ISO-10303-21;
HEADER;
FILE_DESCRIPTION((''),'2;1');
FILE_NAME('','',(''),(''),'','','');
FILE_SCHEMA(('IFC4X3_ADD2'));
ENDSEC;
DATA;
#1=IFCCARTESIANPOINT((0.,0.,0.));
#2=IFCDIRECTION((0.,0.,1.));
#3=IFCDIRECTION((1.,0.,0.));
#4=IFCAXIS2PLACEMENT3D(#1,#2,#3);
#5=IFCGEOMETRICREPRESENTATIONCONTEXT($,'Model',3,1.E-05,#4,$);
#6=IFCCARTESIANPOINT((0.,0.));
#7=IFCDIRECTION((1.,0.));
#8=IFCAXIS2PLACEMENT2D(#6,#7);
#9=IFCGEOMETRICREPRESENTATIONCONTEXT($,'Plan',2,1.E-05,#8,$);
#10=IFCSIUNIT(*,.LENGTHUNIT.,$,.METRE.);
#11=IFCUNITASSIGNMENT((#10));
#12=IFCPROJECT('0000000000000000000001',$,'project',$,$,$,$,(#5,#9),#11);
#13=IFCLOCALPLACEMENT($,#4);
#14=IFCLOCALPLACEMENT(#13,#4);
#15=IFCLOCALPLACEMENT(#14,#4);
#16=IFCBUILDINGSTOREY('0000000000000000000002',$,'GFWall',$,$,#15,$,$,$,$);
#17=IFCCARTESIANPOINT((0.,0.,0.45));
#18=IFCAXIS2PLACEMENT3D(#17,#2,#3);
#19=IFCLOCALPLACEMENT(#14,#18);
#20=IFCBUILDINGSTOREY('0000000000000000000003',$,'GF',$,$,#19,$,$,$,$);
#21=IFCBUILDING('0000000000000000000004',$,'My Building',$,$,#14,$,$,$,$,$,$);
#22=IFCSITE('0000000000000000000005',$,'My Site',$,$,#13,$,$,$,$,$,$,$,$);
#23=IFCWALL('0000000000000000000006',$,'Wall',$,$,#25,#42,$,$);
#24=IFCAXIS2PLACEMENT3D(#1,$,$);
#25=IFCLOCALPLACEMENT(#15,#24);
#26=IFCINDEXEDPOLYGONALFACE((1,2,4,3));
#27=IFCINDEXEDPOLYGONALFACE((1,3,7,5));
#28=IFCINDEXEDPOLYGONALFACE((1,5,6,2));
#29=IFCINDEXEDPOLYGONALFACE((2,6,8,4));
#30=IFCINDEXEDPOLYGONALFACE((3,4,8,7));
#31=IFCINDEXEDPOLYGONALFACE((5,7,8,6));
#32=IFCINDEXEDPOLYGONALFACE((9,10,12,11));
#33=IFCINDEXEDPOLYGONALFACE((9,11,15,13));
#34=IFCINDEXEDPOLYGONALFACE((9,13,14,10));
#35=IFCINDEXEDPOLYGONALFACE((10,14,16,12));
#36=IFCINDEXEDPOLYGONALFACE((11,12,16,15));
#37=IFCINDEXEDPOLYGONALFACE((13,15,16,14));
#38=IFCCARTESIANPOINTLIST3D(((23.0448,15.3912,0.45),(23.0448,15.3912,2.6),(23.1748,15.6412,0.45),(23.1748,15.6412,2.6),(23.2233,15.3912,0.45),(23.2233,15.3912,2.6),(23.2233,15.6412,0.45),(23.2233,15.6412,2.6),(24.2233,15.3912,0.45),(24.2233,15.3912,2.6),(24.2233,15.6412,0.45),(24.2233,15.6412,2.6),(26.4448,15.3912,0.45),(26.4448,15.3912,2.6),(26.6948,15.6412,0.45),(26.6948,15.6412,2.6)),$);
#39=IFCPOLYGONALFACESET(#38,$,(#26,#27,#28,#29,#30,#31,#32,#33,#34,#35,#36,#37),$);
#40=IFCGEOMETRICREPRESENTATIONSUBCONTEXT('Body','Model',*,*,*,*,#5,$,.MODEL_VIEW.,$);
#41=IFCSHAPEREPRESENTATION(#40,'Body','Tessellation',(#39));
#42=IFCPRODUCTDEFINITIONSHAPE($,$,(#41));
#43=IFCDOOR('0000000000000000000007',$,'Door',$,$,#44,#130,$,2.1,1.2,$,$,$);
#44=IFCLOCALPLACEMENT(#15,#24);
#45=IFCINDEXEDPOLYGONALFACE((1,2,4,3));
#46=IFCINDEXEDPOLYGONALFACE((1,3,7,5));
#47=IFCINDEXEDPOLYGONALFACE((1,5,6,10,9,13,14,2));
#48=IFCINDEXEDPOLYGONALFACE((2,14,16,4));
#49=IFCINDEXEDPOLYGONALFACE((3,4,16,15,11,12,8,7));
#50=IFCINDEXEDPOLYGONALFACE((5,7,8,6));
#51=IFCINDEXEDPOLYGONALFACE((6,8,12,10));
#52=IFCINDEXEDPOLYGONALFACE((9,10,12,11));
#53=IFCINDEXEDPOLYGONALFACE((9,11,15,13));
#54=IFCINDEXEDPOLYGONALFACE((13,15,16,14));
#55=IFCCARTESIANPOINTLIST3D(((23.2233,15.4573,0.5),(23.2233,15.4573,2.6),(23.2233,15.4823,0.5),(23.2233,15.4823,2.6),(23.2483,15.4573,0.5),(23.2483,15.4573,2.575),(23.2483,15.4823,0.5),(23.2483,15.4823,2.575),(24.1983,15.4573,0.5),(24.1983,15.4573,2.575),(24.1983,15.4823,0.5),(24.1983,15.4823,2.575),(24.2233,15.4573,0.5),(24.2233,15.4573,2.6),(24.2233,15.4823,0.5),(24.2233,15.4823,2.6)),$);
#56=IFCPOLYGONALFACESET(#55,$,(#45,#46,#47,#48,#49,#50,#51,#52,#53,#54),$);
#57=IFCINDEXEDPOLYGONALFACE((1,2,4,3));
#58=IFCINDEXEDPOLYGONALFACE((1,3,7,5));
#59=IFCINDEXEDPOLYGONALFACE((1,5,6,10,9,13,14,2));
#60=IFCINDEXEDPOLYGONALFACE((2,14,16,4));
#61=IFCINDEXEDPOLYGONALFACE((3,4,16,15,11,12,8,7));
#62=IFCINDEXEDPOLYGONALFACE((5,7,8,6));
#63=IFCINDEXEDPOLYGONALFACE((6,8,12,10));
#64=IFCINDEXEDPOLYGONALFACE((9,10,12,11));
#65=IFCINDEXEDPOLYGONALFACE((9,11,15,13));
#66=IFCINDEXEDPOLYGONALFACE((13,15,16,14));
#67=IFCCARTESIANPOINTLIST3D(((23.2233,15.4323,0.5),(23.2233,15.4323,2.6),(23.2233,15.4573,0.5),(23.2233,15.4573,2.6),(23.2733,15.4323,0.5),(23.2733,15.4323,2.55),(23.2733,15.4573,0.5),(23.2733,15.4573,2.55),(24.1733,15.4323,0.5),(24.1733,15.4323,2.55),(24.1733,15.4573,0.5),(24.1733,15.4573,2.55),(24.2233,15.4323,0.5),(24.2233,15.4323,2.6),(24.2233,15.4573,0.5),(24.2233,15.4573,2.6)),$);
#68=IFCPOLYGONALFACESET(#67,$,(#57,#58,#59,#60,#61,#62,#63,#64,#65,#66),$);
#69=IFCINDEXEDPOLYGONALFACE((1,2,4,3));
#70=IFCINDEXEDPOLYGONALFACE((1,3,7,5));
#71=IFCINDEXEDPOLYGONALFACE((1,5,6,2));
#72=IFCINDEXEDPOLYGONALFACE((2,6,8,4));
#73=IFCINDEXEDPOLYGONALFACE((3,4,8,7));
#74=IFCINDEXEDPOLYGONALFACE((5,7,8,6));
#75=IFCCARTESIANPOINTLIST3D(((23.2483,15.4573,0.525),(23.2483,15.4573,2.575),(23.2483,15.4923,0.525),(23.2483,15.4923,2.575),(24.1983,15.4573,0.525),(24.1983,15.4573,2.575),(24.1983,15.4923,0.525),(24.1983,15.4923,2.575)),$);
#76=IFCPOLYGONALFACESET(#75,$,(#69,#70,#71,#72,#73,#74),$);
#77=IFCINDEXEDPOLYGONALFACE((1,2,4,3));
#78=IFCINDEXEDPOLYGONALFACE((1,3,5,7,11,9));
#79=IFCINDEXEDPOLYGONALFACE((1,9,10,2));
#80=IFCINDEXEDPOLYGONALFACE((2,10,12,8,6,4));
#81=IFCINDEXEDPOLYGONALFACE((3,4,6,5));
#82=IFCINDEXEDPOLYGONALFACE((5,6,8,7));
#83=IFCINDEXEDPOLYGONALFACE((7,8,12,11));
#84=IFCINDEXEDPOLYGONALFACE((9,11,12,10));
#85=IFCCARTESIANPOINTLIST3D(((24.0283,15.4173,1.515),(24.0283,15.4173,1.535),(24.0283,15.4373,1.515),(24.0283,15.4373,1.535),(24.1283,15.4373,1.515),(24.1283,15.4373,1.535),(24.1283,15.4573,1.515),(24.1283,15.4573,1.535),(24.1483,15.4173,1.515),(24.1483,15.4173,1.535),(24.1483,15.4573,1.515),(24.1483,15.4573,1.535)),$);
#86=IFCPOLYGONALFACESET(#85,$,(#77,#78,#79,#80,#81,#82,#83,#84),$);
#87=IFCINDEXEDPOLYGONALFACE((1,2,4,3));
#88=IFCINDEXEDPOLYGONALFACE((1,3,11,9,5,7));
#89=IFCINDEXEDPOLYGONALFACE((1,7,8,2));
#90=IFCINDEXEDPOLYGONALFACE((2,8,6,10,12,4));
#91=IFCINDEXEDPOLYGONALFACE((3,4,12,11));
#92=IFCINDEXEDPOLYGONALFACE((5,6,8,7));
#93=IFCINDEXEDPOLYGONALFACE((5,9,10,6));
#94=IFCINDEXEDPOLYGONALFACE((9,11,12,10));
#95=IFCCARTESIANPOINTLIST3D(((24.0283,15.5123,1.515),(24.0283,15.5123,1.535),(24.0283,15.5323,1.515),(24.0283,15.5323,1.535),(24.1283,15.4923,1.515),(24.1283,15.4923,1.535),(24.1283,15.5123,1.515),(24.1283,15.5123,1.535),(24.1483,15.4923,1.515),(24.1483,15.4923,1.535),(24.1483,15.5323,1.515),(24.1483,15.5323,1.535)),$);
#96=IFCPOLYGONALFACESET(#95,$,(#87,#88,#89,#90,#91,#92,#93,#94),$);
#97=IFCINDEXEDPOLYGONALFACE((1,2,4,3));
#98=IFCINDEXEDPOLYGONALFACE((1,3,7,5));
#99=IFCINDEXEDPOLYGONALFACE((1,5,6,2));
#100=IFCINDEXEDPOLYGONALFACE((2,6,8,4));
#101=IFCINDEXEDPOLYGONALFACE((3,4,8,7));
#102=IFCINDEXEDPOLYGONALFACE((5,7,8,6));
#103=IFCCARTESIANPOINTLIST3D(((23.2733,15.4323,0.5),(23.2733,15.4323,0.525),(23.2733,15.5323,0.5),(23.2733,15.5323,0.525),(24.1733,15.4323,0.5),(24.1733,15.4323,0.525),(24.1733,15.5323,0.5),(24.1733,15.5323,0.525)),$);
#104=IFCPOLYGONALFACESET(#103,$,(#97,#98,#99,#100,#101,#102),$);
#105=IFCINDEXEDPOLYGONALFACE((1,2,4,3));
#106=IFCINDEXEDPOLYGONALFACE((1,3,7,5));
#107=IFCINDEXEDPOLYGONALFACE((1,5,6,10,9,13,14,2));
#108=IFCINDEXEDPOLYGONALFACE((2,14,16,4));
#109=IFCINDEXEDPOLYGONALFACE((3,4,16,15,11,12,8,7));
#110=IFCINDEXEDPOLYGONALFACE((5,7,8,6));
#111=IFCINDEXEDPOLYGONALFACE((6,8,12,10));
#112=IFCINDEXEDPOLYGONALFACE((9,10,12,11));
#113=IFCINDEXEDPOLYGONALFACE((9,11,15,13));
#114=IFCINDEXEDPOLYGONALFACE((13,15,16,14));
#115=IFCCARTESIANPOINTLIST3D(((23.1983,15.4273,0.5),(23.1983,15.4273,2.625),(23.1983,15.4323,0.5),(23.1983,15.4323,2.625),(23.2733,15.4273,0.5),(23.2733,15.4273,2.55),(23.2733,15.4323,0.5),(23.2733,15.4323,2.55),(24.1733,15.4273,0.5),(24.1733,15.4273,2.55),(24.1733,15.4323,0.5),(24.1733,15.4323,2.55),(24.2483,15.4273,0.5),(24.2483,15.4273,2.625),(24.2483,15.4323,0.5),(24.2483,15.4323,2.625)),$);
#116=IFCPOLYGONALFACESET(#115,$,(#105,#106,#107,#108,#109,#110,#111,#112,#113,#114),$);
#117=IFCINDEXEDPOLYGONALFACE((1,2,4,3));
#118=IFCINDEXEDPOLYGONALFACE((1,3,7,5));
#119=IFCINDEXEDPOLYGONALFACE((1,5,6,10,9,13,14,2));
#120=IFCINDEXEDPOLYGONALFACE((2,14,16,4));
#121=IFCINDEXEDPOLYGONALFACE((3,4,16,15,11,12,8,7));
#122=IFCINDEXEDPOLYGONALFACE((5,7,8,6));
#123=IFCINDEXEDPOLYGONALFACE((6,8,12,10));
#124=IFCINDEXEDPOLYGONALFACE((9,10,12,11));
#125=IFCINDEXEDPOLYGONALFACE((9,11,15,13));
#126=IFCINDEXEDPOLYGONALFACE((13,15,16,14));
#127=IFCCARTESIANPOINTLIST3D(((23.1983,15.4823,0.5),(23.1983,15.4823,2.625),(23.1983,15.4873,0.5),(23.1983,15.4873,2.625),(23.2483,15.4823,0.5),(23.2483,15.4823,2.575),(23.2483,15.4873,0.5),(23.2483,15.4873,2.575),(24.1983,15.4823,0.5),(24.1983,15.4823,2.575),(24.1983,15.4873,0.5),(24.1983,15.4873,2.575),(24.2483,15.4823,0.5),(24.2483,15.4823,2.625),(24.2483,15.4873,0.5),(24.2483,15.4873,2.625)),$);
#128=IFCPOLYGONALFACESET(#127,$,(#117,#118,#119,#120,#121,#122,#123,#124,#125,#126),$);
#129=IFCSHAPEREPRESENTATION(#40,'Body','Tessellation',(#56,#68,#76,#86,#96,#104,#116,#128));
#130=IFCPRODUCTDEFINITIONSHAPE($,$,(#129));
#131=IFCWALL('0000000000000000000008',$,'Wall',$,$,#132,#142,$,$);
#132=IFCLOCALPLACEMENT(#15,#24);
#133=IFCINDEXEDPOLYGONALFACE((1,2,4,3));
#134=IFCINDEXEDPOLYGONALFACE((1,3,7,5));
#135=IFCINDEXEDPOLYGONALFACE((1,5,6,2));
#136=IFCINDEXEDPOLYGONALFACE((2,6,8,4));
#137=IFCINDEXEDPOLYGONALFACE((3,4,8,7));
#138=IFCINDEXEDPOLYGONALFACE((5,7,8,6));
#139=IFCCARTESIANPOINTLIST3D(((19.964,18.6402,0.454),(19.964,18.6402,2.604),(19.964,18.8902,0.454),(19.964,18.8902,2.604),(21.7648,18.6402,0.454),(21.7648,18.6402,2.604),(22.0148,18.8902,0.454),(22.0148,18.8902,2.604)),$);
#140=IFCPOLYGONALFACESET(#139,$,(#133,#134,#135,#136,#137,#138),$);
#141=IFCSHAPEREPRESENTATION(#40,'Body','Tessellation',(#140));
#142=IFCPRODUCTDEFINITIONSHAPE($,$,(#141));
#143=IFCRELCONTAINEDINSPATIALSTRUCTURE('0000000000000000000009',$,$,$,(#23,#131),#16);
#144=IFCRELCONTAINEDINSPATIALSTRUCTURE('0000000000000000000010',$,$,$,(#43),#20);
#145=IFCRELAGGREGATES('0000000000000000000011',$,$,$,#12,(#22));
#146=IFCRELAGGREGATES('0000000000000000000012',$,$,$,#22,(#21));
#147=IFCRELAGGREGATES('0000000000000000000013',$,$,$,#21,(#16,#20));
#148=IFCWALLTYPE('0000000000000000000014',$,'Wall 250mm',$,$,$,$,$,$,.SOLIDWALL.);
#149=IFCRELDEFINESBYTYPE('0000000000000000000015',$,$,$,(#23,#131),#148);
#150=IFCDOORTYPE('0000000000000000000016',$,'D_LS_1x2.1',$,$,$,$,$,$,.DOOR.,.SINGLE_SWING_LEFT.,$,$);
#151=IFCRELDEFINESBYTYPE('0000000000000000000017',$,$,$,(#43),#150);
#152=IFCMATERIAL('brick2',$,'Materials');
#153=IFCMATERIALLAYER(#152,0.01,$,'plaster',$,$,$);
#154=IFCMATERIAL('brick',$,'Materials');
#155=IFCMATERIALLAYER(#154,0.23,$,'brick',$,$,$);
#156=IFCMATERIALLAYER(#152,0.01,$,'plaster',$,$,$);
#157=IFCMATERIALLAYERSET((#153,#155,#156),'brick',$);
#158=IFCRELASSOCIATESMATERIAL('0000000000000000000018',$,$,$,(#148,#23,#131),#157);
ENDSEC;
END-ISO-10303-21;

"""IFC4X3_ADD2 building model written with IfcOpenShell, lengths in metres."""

from ifc_helpers import new_model, entity, si_unit, frame, origin_with_axes, origin_2d_with_axis, place, context, subcontext, project, spatial, line, indexed_curve, outline, extrude, shape, source, transform, mapped, material, layer, layer_set, layer_usage, type_object, type_shapes, element, fill, save


model = new_model("IFC4X3_ADD2")

# Units and contexts
model_context = context("Model", 3, precision=1e-05, world=origin_with_axes())
plan_context = context("Plan", 2, precision=1e-05, world=origin_2d_with_axis())
body_context_1 = subcontext(model_context, "Body", "Model", "MODEL_VIEW")
body_context_2 = subcontext(plan_context, "Body", "Plan", "PLAN_VIEW")
ifc_project = project(units=[si_unit("LENGTHUNIT", "METRE")], contexts=[model_context, plan_context])

# Site, building, storey
site_placement = place(None, origin_with_axes())
site = spatial("IfcSite", under=ifc_project, at=site_placement, Name="My Site")
building_placement = place(site_placement, origin_with_axes())
building = spatial("IfcBuilding", under=site, at=building_placement, Name="My Building")
storey_1_placement = place(building_placement, origin_with_axes())
storey_1 = spatial("IfcBuildingStorey", under=building, at=storey_1_placement, Name="GFWall")

# Shared definitions
ifc_material_1 = material(Name="brick2", Category="Materials")
ifc_layer_1 = layer(ifc_material_1, 0.01, Name="plaster")
ifc_material_2 = material(Name="brick", Category="Materials")
ifc_layer_2 = layer(ifc_material_2, 0.23, Name="brick")
ifc_layer_3 = layer(ifc_material_1, 0.01, Name="plaster")
ifc_layer_set_1 = layer_set([ifc_layer_1, ifc_layer_2, ifc_layer_3], Name="brick")
wall_type_1 = type_object("IfcWallType", Name="Wall 250mm", PredefinedType="SOLIDWALL", material=ifc_layer_set_1)

# Shared definitions
storey_2_placement = place(building_placement, frame((0.0, 0.0, 0.45), z_axis=(0.0, 0.0, 1.0), x_axis=(1.0, 0.0, 0.0)))
storey_2 = spatial("IfcBuildingStorey", under=building, at=storey_2_placement, Name="GF")

# Shared definitions
shared_shape_1 = source(origin_with_axes(), body_context_1, "Body", "SweptSolid", [
    extrude(outline(indexed_curve([(0.0, 2.1), (1.0, 2.1), (1.0, -0.05), (0.0, -0.05), (0.0, 2.1)])), frame((0.0, -0.6, 0.0), z_axis=(0.0, -1.0, 0.0), x_axis=(1.0, 0.0, 0.0)), (0.0, 0.0, -1.0), 1.2),
])
door_type_1 = type_object("IfcDoorType", Name="D_LS_1x2.1", OperationType="SINGLE_SWING_LEFT", PredefinedType="DOOR")
shared_shape_2 = source(origin_with_axes(), body_context_1, "Body", "SweptSolid", [
    extrude(outline(indexed_curve([(0.0, 0.0), (0.0, 2.1), (1.0, 2.1), (1.0, 0.0), (0.975, 0.0), (0.975, 2.075), (0.025, 2.075), (0.025, 0.0)], segments=[line(1, 2, 3, 4, 5, 6, 7, 8, 1)])), frame((0.0, 0.025, 0.0), z_axis=(0.0, -1.0, 0.0), x_axis=(1.0, 0.0, 0.0)), (0.0, 0.0, -1.0), 0.025),
    extrude(outline(indexed_curve([(0.0, 0.0), (0.0, 2.1), (1.0, 2.1), (1.0, 0.0), (0.95, 0.0), (0.95, 2.05), (0.05, 2.05), (0.05, 0.0)], segments=[line(1, 2, 3, 4, 5, 6, 7, 8, 1)])), frame((0.0, 0.0, 0.0), z_axis=(0.0, -1.0, 0.0), x_axis=(1.0, 0.0, 0.0)), (0.0, 0.0, -1.0), 0.025),
    extrude(outline(indexed_curve([(0.0, 0.0), (0.95, 0.0), (0.95, 0.035), (0.0, 0.035)], segments=[line(1, 2, 3, 4, 1)])), frame((0.025, 0.025, 0.025), z_axis=(0.0, 0.0, 1.0), x_axis=(1.0, 0.0, 0.0)), (0.0, 0.0, 1.0), 2.05),
    extrude(outline(indexed_curve([(0.0, 0.0), (0.0, -0.04), (-0.12, -0.04), (-0.12, -0.02), (-0.02, -0.02), (-0.02, 0.0)], segments=[line(1, 2, 3, 4, 5, 6, 1)])), frame((0.925, 0.025, 1.015), z_axis=(0.0, 0.0, 1.0), x_axis=(1.0, 0.0, 0.0)), (0.0, 0.0, 1.0), 0.02),
    extrude(outline(indexed_curve([(0.0, 0.0), (0.0, 0.04), (-0.12, 0.04), (-0.12, 0.02), (-0.02, 0.02), (-0.02, 0.0)], segments=[line(1, 2, 3, 4, 5, 6, 1)])), frame((0.925, 0.06, 1.015), z_axis=(0.0, 0.0, 1.0), x_axis=(1.0, 0.0, 0.0)), (0.0, 0.0, 1.0), 0.02),
    extrude(outline(indexed_curve([(0.0, 0.0), (0.9, 0.0), (0.9, 0.1), (0.0, 0.1)], segments=[line(1, 2, 3, 4, 1)])), frame((0.05, 0.0, 0.0), z_axis=(0.0, 0.0, 1.0), x_axis=(1.0, 0.0, 0.0)), (0.0, 0.0, 1.0), 0.025),
    extrude(outline(indexed_curve([(0.0, 0.0), (0.0, 2.125), (1.05, 2.125), (1.05, 0.0), (0.975, 0.0), (0.975, 2.05), (0.075, 2.05), (0.075, 0.0)], segments=[line(1, 2, 3, 4, 5, 6, 7, 8, 1)])), frame((-0.025, -0.005, 0.0), z_axis=(0.0, -1.0, 0.0), x_axis=(1.0, 0.0, 0.0)), (0.0, 0.0, -1.0), 0.005),
    extrude(outline(indexed_curve([(0.0, 0.0), (0.0, 2.125), (1.05, 2.125), (1.05, 0.0), (1.0, 0.0), (1.0, 2.075), (0.05, 2.075), (0.05, 0.0)], segments=[line(1, 2, 3, 4, 5, 6, 7, 8, 1)])), frame((-0.025, 0.05, 0.0), z_axis=(0.0, -1.0, 0.0), x_axis=(1.0, 0.0, 0.0)), (0.0, 0.0, -1.0), 0.005),
])
shared_shape_3 = source(origin_with_axes(), body_context_2, "Body", "Curve2D", [
    entity("IfcIndexedPolyCurve", entity("IfcCartesianPointList2D", [[0.0, 0.0], [0.0, 0.05], [0.025, 0.05], [0.025, 0.025], [0.05, 0.025], [0.05, 0.0]]), [entity("IfcLineIndex", [1, 2, 3, 4, 5, 6, 1])]),
    entity("IfcIndexedPolyCurve", entity("IfcCartesianPointList2D", [[1.0, 0.0], [1.0, 0.05], [0.975, 0.05], [0.975, 0.025], [0.95, 0.025], [0.95, 0.0]]), [entity("IfcLineIndex", [1, 2, 3, 4, 5, 6, 1])]),
    entity("IfcTrimmedCurve", entity("IfcEllipse", entity("IfcAxis2Placement2D", entity("IfcCartesianPoint", [0.06, 0.05]), entity("IfcDirection", [1.0, 0.0])), 0.915, 0.95), [entity("IfcCartesianPoint", [0.975, 0.05])], [entity("IfcCartesianPoint", [0.06, 1.0])], True, "CARTESIAN"),
    entity("IfcIndexedPolyCurve", entity("IfcCartesianPointList2D", [[0.025, 0.05], [0.06, 0.05], [0.06, 1.0], [0.025, 1.0]]), [entity("IfcLineIndex", [1, 2, 3, 4, 1])]),
])
type_shapes(door_type_1, [shared_shape_2, shared_shape_3])

# Wall, opening, door
ifc_layer_usage_1 = layer_usage(ifc_layer_set_1, "AXIS2", "POSITIVE", 0.0)
wall_1_placement = place(storey_1_placement, frame((26.6948, 15.6412, 0.45), z_axis=(0.0, 0.0, 1.0), x_axis=(-1.0, 0.0, 0.0)))
wall_1 = element("IfcWall", 1, at=wall_1_placement, inside=storey_1, type_object=wall_type_1, material=ifc_layer_usage_1, Name="Wall", context=body_context_1, shape_type="SweptSolid", body=[
    extrude(outline(indexed_curve([(0.0, 0.0), (0.25, 0.25), (3.65, 0.25), (3.52, 0.0)], segments=[line(1, 2, 3, 4, 1)])), origin_with_axes(), (0.0, 0.0, 1.0), 2.15),
])
opening_1_placement = place(wall_1_placement, frame((3.4715, 0.209, 0.05), z_axis=(0.0, 0.0, 1.0), x_axis=(-1.0, 0.0, 0.0)))
opening_1 = element("IfcOpeningElement", 2, at=opening_1_placement, cuts=wall_1, PredefinedType="OPENING", context=body_context_1, shape_type="MappedRepresentation", body=[
    mapped(shared_shape_1, transform((0.0, 0.0, 0.0), x_axis=(1.0, 0.0, 0.0), y_axis=(0.0, 1.0, 0.0), z_axis=(0.0, 0.0, 1.0), scale=1.0)),
])
door_1_placement = place(opening_1_placement, frame((0.0, 0.0, 0.0), z_axis=(0.0, 0.0, 1.0), x_axis=(1.0, 0.0, 0.0)))
door_1 = element("IfcDoor", 3, at=door_1_placement, inside=storey_2, type_object=door_type_1, Name="Door", OverallHeight=2.1, OverallWidth=1.2, shapes=[
    shape(body_context_1, "Body", "MappedRepresentation", [mapped(shared_shape_2, transform((0.0, 0.0, 0.0), x_axis=(1.0, 0.0, 0.0), y_axis=(0.0, 1.0, 0.0), z_axis=(0.0, 0.0, 1.0), scale=1.0))]),
    shape(body_context_2, "Body", "MappedRepresentation", [mapped(shared_shape_3, transform((0.0, 0.0, 0.0), x_axis=(1.0, 0.0, 0.0), y_axis=(0.0, 1.0, 0.0), z_axis=(0.0, 0.0, 1.0), scale=1.0))]),
])
fill(opening_1, door_1)

# Wall
ifc_layer_usage_2 = layer_usage(ifc_layer_set_1, "AXIS2", "POSITIVE", 0.0)
wall_2_placement = place(storey_1_placement, frame((19.714, 18.6402, 0.454), z_axis=(0.0, 0.0, 1.0), x_axis=(1.0, -0.000001, 0.0)))
element("IfcWall", 4, at=wall_2_placement, inside=storey_1, type_object=wall_type_1, material=ifc_layer_usage_2, Name="Wall", context=body_context_1, shape_type="SweptSolid", body=[
    extrude(outline(indexed_curve([(0.25, 0.0), (0.25, 0.25), (2.3008, 0.25), (2.0508, 0.0)], segments=[line(1, 2, 3, 4, 1)])), origin_with_axes(), (0.0, 0.0, 1.0), 2.15),
])

save(model, "model.ifc")
